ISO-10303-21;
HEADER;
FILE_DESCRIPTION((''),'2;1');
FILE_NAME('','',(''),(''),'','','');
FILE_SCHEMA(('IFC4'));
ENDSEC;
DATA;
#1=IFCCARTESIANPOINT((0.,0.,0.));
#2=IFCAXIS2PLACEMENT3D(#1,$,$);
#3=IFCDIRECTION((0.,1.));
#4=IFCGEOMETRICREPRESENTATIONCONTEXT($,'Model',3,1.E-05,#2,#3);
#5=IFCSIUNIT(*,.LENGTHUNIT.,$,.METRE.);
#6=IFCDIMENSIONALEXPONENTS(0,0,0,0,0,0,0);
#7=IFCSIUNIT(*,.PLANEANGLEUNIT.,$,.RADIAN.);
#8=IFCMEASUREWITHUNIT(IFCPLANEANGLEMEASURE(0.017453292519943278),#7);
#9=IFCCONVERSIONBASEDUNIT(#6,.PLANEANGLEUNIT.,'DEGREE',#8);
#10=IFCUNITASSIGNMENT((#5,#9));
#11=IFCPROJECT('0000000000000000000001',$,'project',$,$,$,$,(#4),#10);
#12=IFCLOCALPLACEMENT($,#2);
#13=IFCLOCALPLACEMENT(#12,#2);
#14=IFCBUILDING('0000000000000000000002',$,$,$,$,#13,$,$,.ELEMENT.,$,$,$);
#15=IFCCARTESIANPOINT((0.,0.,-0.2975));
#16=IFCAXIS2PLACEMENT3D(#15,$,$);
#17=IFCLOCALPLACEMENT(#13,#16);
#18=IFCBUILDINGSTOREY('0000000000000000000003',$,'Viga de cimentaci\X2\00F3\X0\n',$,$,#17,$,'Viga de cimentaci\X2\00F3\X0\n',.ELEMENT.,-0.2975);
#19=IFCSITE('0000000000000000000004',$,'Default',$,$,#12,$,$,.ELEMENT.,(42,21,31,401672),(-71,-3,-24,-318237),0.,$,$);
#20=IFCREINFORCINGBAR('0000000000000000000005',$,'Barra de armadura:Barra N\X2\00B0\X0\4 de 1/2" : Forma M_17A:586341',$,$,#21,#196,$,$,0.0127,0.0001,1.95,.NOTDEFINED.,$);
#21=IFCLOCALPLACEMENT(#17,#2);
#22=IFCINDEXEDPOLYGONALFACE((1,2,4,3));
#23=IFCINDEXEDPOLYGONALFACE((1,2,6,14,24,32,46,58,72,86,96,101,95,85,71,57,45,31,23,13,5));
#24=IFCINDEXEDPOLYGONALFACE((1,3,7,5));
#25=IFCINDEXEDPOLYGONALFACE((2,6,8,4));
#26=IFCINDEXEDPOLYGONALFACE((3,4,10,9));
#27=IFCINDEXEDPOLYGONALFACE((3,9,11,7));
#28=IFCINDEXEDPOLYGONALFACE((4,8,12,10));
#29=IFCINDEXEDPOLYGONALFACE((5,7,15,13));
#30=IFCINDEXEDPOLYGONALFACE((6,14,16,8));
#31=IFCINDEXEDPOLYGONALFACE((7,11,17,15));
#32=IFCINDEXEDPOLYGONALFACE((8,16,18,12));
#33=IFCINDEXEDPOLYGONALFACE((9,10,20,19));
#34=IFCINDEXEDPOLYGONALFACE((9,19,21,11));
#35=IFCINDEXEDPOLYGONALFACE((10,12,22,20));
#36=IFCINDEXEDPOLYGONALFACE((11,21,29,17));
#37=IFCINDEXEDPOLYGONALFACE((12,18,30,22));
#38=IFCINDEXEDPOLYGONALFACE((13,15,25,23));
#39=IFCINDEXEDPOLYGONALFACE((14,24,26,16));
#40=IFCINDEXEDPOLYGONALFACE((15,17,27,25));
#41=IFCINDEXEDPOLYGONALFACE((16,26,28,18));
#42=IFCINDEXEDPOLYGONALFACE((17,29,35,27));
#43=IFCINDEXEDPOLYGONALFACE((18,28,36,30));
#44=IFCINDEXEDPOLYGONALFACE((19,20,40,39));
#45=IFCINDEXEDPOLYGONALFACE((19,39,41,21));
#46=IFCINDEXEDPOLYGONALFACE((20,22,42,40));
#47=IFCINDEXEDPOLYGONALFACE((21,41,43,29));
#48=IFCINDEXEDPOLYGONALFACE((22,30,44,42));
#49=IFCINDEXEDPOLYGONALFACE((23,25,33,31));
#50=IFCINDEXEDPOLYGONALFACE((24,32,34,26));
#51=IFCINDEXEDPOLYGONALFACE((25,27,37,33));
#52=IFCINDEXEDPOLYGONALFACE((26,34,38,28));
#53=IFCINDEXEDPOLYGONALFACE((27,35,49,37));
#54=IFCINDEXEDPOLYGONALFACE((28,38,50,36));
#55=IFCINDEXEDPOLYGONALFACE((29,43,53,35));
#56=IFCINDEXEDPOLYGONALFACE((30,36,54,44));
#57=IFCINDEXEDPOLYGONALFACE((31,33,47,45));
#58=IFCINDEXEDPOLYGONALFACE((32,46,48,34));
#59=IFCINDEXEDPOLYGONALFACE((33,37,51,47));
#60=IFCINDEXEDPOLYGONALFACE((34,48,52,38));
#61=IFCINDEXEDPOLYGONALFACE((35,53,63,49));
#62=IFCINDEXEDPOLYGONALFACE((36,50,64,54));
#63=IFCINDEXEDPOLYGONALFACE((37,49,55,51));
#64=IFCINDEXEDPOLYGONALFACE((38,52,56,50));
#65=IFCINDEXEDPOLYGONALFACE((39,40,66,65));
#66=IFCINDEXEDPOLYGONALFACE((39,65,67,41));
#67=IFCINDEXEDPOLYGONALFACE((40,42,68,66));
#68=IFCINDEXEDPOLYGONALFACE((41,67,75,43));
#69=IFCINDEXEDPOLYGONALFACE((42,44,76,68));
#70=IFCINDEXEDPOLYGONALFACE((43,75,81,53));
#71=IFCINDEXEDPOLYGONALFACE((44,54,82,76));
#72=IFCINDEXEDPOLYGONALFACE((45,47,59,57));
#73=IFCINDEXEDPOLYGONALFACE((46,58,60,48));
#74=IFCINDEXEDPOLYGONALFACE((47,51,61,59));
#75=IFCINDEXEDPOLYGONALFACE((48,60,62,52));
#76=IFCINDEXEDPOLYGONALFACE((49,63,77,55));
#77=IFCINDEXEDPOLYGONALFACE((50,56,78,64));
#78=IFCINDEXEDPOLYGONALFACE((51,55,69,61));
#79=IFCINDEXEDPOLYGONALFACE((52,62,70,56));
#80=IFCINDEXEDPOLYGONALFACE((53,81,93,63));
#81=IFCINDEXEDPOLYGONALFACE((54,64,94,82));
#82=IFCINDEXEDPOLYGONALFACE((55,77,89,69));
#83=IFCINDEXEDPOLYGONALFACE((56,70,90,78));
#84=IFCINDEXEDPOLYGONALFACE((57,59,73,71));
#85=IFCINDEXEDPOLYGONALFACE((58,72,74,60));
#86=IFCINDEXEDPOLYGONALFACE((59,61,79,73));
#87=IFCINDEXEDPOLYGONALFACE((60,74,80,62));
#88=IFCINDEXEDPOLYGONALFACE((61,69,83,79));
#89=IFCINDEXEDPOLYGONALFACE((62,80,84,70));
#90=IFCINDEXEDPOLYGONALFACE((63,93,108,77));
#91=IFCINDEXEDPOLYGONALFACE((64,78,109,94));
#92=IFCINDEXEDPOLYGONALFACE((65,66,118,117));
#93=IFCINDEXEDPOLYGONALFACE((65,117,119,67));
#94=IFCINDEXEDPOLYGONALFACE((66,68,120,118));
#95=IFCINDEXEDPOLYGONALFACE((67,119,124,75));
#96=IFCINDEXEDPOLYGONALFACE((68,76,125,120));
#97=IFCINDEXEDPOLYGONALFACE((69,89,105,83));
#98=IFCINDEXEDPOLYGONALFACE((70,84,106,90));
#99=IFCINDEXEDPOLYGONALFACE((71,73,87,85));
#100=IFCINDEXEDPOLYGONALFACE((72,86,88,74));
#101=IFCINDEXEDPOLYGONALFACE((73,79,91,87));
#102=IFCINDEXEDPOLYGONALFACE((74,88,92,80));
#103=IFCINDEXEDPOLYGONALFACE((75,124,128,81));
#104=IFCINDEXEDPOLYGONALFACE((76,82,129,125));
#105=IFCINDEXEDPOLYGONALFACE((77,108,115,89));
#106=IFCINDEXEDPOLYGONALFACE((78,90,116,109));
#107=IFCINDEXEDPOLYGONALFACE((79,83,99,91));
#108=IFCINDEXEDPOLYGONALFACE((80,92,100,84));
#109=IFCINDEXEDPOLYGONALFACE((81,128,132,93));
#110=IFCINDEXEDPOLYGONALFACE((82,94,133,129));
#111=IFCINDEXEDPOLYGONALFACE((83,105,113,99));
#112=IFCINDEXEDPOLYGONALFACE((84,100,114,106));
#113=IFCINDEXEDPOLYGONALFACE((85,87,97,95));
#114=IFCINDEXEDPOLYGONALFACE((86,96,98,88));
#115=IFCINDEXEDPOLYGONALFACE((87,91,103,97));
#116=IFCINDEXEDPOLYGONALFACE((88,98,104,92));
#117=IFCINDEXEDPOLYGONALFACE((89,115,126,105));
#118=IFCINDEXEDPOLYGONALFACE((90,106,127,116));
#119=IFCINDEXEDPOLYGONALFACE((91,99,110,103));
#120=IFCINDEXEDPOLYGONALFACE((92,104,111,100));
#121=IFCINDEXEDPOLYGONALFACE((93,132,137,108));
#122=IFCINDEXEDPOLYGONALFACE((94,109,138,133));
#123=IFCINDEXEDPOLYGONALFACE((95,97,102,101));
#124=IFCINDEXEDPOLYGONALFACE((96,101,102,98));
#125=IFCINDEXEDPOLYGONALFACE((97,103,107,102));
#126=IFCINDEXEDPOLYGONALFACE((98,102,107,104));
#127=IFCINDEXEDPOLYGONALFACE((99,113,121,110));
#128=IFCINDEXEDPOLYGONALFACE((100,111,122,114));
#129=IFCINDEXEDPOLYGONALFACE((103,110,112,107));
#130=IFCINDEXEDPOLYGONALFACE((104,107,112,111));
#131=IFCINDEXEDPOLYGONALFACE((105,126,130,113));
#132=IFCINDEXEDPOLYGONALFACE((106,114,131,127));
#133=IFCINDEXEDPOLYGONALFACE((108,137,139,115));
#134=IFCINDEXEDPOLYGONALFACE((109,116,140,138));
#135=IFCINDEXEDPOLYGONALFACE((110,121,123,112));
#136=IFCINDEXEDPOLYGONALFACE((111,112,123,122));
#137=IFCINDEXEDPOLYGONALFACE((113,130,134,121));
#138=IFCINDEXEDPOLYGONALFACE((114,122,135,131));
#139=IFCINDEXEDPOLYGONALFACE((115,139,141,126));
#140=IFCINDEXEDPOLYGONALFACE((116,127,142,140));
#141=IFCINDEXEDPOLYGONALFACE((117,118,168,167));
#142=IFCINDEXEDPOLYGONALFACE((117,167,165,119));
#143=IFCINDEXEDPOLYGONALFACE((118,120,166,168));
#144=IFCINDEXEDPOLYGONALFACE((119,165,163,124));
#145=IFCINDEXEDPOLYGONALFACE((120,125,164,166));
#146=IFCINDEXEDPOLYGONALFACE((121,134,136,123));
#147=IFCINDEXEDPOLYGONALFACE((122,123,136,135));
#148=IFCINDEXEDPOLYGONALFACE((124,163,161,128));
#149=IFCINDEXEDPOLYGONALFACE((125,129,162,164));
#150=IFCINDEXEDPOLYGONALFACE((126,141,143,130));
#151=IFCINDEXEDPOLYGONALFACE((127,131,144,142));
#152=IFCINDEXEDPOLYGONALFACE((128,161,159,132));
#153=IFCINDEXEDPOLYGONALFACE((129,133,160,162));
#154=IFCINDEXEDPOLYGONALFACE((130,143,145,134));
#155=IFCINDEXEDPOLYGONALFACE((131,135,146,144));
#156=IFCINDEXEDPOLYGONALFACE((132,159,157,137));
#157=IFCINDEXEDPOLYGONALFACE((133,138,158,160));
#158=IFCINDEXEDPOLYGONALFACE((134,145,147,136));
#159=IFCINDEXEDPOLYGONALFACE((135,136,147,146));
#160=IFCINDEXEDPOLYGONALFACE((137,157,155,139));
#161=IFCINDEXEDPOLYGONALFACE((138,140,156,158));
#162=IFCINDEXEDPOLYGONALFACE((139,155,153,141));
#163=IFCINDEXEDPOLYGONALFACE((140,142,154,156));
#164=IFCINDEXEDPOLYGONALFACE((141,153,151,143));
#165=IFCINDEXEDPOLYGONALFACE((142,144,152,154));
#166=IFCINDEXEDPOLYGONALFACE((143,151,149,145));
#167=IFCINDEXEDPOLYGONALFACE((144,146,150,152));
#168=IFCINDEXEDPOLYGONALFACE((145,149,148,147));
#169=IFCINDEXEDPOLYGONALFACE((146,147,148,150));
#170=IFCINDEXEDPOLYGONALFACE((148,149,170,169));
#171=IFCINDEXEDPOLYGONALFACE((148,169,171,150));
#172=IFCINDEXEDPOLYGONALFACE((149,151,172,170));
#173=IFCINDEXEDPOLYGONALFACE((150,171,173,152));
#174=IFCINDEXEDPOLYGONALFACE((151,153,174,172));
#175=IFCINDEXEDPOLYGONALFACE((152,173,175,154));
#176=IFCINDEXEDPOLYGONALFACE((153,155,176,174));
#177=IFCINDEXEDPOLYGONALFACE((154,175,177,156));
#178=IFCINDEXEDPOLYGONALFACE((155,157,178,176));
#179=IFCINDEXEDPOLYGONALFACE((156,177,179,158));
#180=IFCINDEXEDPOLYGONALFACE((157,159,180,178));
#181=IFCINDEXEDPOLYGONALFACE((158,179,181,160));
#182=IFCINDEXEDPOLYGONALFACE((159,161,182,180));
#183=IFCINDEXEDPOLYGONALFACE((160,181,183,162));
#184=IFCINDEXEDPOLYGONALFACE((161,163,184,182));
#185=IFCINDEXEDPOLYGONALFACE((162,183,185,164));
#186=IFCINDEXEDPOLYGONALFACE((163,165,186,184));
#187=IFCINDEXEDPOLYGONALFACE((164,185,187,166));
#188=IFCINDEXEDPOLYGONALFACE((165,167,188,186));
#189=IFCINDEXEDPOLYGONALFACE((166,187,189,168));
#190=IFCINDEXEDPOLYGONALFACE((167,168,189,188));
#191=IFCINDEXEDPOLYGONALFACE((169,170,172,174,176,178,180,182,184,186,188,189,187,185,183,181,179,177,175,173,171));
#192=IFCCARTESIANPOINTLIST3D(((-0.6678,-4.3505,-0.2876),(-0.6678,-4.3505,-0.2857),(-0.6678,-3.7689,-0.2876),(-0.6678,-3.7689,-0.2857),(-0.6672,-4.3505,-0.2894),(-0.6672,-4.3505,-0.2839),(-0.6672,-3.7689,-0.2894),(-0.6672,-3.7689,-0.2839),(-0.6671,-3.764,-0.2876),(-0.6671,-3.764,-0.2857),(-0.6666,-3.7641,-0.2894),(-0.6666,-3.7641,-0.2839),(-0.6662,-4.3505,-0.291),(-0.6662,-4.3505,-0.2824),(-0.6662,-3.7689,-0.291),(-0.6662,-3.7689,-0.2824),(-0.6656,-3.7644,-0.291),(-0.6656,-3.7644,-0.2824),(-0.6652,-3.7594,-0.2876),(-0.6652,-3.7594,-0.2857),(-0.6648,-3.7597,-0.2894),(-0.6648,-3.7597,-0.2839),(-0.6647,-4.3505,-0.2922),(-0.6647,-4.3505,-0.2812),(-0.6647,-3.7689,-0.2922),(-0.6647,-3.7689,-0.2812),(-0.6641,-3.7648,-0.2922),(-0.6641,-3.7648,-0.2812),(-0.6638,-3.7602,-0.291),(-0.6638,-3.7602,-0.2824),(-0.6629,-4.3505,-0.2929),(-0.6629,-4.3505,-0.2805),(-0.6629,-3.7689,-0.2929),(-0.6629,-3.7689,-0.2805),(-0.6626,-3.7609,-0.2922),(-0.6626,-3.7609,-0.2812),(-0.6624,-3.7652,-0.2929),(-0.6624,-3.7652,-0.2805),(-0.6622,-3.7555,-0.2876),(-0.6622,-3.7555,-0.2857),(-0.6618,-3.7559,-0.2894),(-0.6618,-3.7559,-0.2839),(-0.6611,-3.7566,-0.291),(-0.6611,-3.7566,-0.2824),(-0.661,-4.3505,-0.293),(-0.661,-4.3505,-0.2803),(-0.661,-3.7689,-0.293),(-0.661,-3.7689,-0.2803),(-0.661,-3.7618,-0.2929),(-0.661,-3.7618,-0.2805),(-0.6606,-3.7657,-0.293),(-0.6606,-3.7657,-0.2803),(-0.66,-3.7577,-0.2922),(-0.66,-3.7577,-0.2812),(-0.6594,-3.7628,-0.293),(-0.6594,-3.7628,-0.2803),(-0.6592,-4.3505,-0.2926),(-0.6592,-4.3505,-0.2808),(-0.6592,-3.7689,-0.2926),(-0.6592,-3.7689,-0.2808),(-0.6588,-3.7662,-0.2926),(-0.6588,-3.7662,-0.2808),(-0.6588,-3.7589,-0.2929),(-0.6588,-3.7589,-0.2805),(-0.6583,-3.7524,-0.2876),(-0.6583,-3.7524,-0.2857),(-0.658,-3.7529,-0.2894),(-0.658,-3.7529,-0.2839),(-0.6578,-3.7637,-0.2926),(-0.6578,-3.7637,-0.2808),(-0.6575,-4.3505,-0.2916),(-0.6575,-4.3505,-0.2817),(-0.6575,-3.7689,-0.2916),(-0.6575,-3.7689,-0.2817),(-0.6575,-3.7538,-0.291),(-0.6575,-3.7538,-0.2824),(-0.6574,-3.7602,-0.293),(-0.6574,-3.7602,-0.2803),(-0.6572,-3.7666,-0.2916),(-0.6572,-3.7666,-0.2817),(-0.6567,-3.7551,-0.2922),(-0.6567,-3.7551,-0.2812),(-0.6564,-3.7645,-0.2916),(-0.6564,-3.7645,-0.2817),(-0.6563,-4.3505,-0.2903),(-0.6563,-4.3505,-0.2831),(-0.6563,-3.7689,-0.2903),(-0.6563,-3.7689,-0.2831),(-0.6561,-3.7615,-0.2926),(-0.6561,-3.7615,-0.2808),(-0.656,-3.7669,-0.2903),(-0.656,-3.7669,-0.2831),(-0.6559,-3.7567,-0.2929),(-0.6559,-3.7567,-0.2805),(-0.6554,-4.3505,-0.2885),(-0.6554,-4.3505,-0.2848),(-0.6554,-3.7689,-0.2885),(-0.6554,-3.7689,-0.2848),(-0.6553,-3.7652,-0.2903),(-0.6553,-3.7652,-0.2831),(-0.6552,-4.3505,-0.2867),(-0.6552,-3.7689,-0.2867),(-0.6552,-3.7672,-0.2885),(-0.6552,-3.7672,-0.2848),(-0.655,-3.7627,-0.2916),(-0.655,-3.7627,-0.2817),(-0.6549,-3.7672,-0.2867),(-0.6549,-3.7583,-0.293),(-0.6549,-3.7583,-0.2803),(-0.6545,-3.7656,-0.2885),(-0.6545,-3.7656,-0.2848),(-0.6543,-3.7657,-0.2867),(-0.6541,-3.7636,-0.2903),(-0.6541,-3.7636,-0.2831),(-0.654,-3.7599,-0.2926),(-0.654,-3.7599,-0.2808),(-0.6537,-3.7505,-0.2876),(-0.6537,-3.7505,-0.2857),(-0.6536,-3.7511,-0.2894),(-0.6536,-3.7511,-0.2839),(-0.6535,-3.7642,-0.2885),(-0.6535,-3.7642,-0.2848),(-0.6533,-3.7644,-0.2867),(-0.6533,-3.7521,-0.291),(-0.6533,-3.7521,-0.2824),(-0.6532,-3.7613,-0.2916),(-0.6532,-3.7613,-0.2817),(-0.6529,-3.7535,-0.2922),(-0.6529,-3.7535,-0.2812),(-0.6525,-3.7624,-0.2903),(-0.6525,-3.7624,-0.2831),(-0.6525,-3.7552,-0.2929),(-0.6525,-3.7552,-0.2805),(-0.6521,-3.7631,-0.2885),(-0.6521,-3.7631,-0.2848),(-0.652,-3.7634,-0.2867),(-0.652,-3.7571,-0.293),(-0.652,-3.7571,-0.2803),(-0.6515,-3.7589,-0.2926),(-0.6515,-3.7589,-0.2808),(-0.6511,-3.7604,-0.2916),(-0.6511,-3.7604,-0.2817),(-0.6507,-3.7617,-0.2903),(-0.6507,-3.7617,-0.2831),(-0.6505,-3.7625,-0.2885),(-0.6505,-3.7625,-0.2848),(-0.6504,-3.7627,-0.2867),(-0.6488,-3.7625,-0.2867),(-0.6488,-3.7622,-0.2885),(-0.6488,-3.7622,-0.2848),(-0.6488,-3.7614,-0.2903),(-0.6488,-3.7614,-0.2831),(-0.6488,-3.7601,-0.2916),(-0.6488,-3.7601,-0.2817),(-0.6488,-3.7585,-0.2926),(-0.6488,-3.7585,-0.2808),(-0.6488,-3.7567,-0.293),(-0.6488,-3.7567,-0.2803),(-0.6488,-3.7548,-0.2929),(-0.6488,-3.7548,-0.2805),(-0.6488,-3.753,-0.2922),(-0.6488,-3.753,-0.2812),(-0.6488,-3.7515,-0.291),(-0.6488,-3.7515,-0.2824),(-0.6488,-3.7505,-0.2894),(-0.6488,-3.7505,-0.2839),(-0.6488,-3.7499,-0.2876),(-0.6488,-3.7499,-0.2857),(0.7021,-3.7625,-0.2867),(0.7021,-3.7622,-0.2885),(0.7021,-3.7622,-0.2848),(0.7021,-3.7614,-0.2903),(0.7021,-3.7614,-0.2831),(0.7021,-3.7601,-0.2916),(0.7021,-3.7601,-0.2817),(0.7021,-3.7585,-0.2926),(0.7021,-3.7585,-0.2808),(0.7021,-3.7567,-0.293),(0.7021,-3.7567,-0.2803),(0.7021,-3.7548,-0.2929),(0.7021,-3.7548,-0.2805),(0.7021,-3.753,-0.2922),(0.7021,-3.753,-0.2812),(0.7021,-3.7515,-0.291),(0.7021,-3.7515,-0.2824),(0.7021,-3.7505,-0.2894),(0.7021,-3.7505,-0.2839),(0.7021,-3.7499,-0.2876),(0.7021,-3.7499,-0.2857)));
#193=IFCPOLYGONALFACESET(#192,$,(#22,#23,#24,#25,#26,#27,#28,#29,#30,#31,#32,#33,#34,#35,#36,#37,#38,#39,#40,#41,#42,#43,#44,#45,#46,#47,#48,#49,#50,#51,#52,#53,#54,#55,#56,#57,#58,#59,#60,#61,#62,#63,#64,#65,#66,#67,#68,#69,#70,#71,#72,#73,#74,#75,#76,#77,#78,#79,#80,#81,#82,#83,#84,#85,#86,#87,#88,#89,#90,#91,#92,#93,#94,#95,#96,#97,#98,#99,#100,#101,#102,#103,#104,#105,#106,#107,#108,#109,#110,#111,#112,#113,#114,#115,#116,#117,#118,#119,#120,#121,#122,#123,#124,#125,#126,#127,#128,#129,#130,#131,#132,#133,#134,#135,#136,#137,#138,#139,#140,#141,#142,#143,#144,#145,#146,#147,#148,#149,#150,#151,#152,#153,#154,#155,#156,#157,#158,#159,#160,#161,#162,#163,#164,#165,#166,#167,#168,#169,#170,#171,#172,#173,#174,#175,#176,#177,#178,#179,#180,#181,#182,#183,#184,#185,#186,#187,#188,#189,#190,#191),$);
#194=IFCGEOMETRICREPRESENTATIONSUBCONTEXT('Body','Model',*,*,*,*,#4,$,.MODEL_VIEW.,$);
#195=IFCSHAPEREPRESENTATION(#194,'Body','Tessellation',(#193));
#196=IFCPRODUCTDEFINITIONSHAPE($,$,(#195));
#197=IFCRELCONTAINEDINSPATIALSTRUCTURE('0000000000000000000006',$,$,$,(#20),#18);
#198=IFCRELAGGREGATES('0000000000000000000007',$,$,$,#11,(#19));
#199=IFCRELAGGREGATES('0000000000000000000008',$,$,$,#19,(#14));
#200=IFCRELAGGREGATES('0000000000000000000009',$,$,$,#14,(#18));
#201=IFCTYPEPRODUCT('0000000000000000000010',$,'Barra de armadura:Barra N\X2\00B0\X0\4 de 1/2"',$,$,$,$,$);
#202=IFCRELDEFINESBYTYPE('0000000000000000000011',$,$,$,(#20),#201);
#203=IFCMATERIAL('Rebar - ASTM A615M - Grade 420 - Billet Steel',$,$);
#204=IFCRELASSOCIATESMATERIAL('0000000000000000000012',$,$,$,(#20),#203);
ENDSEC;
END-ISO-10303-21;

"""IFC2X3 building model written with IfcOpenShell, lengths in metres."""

from ifc_helpers import new_model, entity, si_unit, converted_unit, direction, frame, origin, place, context, subcontext, project, spatial, material, type_object, element, save


model = new_model("IFC2X3")

# Units and contexts
model_context = context("Model", 3, precision=1e-05, world=origin(), true_north=direction((0.0, 1.0)))
body_context = subcontext(model_context, "Body", "Model", "MODEL_VIEW")
ifc_project = project(units=[si_unit("LENGTHUNIT", "METRE"), converted_unit("PLANEANGLEUNIT", "DEGREE", entity("IfcPlaneAngleMeasure", 0.017453292519943278), si_unit("PLANEANGLEUNIT", "RADIAN"), dimensions=[0, 0, 0, 0, 0, 0, 0])], contexts=[model_context])

# Site, building, storey
site_placement = place(None, origin())
site = spatial("IfcSite", under=ifc_project, at=site_placement, Name="Default", CompositionType="ELEMENT", RefLatitude=(42, 21, 31, 401672), RefLongitude=(-71, -3, -24, -318237), RefElevation=0.0)
building_placement = place(site_placement, origin())
building = spatial("IfcBuilding", under=site, at=building_placement, CompositionType="ELEMENT")
storey_placement = place(building_placement, frame((0.0, 0.0, -0.2975)))
storey = spatial("IfcBuildingStorey", under=building, at=storey_placement, Name="Viga de cimentación", LongName="Viga de cimentación", CompositionType="ELEMENT", Elevation=-0.2975)

# Reinforcing bar
ifc_material = material(Name="Rebar - ASTM A615M - Grade 420 - Billet Steel")
type_product_1 = type_object("IfcTypeProduct", Name="Barra de armadura:Barra N°4 de 1/2\"")
reinforcing_bar_1_placement = place(storey_placement, origin())
element("IfcReinforcingBar", 1, at=reinforcing_bar_1_placement, inside=storey, type_object=type_product_1, material=ifc_material, Name="Barra de armadura:Barra N°4 de 1/2\" : Forma M_17A:586341", BarLength=1.95, BarRole="NOTDEFINED", CrossSectionArea=0.0001, NominalDiameter=0.0127, context=body_context, shape_type="AdvancedSweptSolid", body=[
    entity("IfcSweptDiskSolid", entity("IfcCompositeCurve", [entity("IfcCompositeCurveSegment", "CONTINUOUS", True, entity("IfcPolyline", [entity("IfcCartesianPoint", [-0.6615, -4.3505, -0.2867]), entity("IfcCartesianPoint", [-0.6615, -3.7689, -0.2867])])), entity("IfcCompositeCurveSegment", "CONTINUOUS", True, entity("IfcTrimmedCurve", entity("IfcCircle", entity("IfcAxis2Placement3D", entity("IfcCartesianPoint", [-0.6488, -3.7689, -0.2867]), entity("IfcDirection", [0.0, 0.0, -1.0]), entity("IfcDirection", [0.0, 1.0, 0.0])), 0.0127), [entity("IfcParameterValue", 270.0)], [entity("IfcParameterValue", 360.0)], True, "PARAMETER")), entity("IfcCompositeCurveSegment", "CONTINUOUS", True, entity("IfcPolyline", [entity("IfcCartesianPoint", [-0.6488, -3.7562, -0.2867]), entity("IfcCartesianPoint", [0.7021, -3.7562, -0.2867])]))], False), 0.0063, None, 0.0, 92.0),
])

save(model, "model.ifc")
